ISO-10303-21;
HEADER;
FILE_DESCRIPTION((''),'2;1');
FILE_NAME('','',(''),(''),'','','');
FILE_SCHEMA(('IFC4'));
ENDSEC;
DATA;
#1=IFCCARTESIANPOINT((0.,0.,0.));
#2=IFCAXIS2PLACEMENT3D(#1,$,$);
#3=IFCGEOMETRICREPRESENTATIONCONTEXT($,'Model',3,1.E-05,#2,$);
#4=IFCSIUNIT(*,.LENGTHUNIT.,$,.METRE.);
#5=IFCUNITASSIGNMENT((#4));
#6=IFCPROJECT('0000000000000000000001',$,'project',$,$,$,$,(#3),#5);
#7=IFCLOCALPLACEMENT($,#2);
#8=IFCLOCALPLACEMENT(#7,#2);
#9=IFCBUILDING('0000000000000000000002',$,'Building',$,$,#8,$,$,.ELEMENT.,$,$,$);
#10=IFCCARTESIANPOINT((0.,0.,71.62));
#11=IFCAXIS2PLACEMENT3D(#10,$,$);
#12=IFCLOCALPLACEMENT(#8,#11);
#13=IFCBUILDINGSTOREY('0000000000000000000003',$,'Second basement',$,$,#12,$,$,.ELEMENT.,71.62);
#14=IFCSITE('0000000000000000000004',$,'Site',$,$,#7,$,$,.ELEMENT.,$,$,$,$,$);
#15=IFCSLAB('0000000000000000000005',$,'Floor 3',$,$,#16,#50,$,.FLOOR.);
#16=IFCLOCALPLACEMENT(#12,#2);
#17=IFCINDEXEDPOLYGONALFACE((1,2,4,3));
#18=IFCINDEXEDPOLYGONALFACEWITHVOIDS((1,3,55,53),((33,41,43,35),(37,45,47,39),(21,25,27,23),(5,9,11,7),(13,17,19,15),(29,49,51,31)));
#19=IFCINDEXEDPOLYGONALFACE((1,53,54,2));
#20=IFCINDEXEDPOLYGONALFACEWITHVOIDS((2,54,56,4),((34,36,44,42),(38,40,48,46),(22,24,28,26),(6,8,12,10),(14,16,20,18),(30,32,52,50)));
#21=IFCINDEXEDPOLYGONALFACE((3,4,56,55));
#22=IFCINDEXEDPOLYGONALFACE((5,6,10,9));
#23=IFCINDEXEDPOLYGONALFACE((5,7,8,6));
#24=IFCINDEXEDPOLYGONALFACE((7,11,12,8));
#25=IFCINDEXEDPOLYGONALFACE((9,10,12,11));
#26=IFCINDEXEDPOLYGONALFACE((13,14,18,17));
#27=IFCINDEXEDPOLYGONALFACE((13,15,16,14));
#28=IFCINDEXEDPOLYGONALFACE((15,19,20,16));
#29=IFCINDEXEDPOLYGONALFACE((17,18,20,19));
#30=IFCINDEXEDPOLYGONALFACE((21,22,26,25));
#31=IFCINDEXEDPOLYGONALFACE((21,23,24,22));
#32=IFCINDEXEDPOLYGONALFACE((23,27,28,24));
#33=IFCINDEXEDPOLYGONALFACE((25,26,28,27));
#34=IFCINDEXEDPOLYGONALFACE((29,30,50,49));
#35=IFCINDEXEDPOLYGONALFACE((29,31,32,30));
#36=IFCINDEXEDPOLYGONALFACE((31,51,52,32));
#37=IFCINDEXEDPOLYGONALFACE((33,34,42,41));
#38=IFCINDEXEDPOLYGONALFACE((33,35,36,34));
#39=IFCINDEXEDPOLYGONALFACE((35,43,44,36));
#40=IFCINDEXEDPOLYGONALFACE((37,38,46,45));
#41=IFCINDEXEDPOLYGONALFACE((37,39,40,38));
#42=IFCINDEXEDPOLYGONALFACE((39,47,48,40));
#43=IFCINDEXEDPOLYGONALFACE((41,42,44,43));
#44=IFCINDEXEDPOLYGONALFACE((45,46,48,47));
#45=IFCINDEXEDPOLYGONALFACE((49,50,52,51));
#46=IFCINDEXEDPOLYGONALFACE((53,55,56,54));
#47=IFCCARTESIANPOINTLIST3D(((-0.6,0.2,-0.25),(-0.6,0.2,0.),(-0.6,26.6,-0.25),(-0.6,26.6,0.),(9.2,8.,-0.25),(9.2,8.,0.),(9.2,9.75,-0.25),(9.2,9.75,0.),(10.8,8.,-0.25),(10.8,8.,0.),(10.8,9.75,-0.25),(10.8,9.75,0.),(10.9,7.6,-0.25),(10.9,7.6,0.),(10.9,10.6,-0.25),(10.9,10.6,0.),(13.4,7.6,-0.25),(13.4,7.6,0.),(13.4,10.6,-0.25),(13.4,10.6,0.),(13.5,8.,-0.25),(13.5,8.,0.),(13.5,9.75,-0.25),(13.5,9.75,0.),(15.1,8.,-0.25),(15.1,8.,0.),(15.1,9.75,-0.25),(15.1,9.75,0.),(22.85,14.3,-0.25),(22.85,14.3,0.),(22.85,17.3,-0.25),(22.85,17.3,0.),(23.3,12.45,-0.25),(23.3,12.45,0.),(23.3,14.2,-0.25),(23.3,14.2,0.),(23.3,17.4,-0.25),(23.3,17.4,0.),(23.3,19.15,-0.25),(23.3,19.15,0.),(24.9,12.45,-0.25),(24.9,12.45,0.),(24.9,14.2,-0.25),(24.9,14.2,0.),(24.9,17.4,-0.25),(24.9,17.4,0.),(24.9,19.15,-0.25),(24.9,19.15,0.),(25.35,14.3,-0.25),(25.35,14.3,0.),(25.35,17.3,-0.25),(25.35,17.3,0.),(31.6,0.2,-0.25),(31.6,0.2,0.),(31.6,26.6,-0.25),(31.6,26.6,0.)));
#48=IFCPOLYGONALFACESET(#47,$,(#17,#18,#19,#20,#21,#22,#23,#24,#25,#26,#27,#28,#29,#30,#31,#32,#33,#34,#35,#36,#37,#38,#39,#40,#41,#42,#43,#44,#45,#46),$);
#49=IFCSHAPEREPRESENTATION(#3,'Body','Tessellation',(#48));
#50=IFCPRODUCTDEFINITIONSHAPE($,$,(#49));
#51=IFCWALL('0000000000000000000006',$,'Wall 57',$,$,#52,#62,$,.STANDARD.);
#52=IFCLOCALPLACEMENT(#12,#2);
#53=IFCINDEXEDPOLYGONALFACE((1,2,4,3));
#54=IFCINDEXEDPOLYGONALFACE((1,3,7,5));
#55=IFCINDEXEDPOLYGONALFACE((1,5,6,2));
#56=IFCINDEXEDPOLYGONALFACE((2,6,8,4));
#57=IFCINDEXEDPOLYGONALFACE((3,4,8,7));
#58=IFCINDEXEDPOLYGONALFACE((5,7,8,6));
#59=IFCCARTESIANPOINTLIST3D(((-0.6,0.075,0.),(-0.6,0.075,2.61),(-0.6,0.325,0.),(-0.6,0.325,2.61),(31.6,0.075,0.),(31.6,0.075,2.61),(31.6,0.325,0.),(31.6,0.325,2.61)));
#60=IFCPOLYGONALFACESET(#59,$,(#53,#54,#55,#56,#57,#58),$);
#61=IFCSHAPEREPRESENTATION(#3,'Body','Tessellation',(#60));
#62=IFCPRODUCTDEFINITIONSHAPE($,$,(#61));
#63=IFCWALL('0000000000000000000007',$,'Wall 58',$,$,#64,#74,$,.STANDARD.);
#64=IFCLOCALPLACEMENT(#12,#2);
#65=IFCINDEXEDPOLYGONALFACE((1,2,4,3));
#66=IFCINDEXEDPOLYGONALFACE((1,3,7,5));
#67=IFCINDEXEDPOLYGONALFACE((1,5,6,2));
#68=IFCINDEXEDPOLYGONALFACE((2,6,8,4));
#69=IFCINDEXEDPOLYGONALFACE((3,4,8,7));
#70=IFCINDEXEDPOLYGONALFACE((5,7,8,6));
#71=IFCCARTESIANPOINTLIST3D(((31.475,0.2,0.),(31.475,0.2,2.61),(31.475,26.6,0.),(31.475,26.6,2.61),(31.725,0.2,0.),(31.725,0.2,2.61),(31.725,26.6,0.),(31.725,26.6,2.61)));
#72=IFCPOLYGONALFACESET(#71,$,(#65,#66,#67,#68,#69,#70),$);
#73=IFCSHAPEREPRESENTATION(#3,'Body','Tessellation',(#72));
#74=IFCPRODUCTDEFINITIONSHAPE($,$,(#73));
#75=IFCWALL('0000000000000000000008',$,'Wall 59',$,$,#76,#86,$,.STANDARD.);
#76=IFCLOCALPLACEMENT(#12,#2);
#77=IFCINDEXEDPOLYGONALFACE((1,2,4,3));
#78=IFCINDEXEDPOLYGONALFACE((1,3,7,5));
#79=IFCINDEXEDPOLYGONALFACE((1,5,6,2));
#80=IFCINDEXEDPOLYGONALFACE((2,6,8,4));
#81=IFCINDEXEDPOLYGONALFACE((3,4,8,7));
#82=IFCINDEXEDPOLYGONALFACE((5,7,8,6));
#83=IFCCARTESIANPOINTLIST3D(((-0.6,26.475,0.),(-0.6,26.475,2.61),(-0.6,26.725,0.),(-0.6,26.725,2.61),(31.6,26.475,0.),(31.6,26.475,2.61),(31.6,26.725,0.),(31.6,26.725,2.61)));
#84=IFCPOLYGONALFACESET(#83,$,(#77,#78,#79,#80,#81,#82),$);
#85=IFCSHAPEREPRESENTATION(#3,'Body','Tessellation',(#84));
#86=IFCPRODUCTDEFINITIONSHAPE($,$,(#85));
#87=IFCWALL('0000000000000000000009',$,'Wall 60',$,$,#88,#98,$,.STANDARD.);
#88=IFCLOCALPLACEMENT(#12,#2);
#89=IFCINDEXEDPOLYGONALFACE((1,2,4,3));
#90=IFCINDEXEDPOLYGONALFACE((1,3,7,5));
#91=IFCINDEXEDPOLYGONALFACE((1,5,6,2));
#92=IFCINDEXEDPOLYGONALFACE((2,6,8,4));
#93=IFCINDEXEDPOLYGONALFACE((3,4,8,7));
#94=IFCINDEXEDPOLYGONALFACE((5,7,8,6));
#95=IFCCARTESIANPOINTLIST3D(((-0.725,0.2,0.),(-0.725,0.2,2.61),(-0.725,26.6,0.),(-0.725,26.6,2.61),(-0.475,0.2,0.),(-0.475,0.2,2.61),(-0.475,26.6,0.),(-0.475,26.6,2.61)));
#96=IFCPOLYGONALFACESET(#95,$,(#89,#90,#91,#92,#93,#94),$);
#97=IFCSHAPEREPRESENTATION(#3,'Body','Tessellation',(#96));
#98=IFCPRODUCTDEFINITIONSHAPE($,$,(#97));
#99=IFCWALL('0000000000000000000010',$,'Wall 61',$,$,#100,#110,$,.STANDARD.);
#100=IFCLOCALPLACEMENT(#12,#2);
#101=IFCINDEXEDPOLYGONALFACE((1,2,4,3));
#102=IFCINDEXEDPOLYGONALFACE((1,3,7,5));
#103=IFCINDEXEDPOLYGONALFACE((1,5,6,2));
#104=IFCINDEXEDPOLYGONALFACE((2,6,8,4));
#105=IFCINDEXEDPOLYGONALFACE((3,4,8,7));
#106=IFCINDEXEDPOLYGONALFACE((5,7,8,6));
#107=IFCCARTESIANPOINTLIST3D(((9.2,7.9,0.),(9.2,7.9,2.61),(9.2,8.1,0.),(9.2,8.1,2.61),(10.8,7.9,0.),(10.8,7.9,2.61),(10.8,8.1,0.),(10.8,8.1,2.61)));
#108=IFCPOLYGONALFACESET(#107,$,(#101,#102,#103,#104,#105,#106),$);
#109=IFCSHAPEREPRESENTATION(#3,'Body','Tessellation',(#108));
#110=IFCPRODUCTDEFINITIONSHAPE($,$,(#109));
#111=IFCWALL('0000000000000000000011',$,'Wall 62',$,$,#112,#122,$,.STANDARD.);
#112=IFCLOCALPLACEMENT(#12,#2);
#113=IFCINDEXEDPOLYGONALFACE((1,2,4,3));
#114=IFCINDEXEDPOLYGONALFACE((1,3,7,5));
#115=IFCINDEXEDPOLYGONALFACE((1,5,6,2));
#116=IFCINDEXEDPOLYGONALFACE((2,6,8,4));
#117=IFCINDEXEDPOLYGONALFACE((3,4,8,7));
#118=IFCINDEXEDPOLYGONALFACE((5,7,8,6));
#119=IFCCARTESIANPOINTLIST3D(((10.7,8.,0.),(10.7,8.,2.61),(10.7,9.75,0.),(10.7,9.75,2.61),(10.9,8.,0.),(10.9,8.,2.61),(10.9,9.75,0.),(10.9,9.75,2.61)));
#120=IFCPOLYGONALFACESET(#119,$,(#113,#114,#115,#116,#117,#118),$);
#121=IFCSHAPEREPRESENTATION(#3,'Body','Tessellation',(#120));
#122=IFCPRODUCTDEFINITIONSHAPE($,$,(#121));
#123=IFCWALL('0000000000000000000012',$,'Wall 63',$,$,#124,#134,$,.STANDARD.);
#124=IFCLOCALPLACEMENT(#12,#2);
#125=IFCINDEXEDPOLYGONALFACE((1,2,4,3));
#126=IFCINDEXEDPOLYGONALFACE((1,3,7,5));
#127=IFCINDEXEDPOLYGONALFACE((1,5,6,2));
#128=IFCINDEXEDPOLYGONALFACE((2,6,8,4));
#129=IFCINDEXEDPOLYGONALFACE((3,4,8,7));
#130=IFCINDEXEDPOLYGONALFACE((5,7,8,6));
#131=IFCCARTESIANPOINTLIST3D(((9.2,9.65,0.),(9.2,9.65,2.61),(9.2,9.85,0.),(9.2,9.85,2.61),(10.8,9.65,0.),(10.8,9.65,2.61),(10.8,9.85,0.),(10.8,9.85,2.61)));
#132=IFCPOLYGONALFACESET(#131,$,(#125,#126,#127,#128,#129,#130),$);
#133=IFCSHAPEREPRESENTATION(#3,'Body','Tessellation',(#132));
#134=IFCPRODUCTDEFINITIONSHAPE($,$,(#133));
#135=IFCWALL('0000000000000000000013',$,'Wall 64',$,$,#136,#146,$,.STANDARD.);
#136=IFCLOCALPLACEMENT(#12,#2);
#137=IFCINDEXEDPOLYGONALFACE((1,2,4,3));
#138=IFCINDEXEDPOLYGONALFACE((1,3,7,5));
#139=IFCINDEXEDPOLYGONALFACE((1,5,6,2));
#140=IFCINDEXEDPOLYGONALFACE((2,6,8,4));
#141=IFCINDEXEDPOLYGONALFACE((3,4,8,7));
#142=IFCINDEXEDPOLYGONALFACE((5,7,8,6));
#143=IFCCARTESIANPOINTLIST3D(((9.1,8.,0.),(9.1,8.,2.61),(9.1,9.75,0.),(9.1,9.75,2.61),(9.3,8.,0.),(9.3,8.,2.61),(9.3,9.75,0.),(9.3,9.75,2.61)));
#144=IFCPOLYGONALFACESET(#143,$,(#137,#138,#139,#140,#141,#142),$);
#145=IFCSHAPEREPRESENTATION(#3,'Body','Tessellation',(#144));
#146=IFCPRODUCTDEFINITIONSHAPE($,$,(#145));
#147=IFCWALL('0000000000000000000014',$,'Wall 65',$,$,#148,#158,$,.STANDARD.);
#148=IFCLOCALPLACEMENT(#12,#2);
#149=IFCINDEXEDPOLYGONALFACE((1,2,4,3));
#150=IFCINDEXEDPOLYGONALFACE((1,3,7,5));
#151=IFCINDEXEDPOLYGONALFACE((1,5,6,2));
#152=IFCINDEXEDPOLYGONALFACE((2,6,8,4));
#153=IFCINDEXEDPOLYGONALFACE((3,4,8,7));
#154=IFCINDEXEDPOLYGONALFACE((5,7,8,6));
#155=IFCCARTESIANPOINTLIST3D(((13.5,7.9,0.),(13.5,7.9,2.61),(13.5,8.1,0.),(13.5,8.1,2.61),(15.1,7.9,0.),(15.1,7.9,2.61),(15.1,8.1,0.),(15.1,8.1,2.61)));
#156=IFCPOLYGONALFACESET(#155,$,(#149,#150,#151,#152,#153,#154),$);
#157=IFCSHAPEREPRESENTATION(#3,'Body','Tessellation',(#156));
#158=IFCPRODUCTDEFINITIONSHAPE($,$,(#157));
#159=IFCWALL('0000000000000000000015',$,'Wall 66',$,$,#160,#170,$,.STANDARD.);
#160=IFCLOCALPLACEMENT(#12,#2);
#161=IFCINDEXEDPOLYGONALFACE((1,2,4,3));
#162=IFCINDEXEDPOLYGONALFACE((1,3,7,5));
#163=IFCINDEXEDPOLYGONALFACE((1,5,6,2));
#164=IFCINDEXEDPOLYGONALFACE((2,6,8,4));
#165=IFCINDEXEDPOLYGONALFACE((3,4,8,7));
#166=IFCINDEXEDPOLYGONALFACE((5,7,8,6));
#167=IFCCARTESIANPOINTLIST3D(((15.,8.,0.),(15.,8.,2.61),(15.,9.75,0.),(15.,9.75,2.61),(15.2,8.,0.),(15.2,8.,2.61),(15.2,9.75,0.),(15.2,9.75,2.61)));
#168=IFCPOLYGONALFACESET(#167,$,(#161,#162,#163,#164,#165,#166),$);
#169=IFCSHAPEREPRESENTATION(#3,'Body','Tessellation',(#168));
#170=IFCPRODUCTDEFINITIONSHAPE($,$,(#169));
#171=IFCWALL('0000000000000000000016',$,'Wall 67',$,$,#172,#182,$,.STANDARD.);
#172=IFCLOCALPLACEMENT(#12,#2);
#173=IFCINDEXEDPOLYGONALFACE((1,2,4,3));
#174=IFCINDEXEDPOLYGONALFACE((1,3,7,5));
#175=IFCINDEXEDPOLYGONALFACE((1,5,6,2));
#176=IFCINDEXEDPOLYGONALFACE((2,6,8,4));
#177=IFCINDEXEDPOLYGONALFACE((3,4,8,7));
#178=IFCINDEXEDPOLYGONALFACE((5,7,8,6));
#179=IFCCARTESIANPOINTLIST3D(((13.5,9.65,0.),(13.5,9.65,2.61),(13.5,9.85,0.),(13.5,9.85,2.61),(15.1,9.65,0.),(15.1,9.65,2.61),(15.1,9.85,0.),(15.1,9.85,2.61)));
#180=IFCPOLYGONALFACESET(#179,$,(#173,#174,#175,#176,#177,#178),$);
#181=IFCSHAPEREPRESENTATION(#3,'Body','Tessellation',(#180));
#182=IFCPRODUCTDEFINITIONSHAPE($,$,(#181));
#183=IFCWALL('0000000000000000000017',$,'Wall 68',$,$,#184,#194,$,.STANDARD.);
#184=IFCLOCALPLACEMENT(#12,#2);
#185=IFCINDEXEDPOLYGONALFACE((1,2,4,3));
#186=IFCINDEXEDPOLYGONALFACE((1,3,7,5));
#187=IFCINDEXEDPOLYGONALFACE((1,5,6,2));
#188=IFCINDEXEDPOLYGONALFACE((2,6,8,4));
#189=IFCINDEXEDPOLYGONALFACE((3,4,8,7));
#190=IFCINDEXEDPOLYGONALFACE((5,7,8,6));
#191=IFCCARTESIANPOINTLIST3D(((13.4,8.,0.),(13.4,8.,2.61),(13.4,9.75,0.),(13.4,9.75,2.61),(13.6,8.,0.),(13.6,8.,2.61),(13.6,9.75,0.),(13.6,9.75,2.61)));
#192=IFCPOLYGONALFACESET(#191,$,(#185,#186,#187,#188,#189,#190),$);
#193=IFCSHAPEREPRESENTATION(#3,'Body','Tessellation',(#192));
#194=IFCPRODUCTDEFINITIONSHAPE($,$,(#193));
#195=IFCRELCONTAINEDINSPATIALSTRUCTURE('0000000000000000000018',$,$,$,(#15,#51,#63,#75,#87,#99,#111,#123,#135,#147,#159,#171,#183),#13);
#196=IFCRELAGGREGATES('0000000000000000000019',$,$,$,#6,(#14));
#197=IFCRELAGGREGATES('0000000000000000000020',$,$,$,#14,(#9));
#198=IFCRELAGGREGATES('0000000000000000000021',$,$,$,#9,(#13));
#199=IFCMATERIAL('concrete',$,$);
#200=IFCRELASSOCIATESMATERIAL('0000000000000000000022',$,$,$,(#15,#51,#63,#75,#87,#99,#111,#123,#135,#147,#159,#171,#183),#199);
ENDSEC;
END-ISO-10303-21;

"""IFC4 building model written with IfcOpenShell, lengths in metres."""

from ifc_helpers import new_model, si_unit, frame, frame_2d, origin, place, context, project, spatial, polyline, rectangle, outline, extrude, material, element, save


model = new_model("IFC4")

# Units and contexts
model_context = context("Model", 3, precision=1e-05, world=origin())
ifc_project = project(units=[si_unit("LENGTHUNIT", "METRE")], contexts=[model_context])

# Site, building, storey
site_placement = place(None, origin())
site = spatial("IfcSite", under=ifc_project, at=site_placement, Name="Site", CompositionType="ELEMENT")
building_placement = place(site_placement, origin())
building = spatial("IfcBuilding", under=site, at=building_placement, Name="Building", CompositionType="ELEMENT")
storey_placement = place(building_placement, frame((0.0, 0.0, 71.62)))
storey = spatial("IfcBuildingStorey", under=building, at=storey_placement, Name="Second basement", CompositionType="ELEMENT", Elevation=71.62)

# Slab
ifc_material = material(Name="concrete")
slab_placement = place(storey_placement, frame((0.0, 0.0, -0.25), z_axis=(0.0, 0.0, 1.0), x_axis=(1.0, 0.0, 0.0)))
element("IfcSlab", 1, at=slab_placement, inside=storey, material=ifc_material, Name="Floor 3", PredefinedType="FLOOR", context=model_context, shape_type="SweptSolid", body=[
    extrude(outline(polyline([(-0.6, 0.2), (31.6, 0.2), (31.6, 26.6), (-0.6, 26.6), (-0.6, 0.2)]), holes=[polyline([(10.9, 7.6), (13.4, 7.6), (13.4, 10.6), (10.9, 10.6), (10.9, 7.6)]), polyline([(9.2, 8.0), (10.8, 8.0), (10.8, 9.75), (9.2, 9.75), (9.2, 8.0)]), polyline([(13.5, 8.0), (15.1, 8.0), (15.1, 9.75), (13.5, 9.75), (13.5, 8.0)]), polyline([(22.85, 14.3), (25.35, 14.3), (25.35, 17.3), (22.85, 17.3), (22.85, 14.3)]), polyline([(23.3, 17.4), (24.9, 17.4), (24.9, 19.15), (23.3, 19.15), (23.3, 17.4)]), polyline([(23.3, 12.45), (24.9, 12.45), (24.9, 14.2), (23.3, 14.2), (23.3, 12.45)])]), origin(), (0.0, 0.0, 1.0), 0.25),
])

# Walls
wall_1_placement = place(storey_placement, frame((-0.6, 0.2, 0.0), z_axis=(0.0, 0.0, 1.0), x_axis=(1.0, 0.0, 0.0)))
element("IfcWall", 2, at=wall_1_placement, inside=storey, material=ifc_material, Name="Wall 57", PredefinedType="STANDARD", context=model_context, shape_type="SweptSolid", body=[
    extrude(rectangle(XDim=32.2, YDim=0.25, at=frame_2d((16.1, 0.0))), origin(), (0.0, 0.0, 1.0), 2.61),
])
wall_2_placement = place(storey_placement, frame((31.6, 0.2, 0.0), z_axis=(0.0, 0.0, 1.0), x_axis=(0.0, 1.0, 0.0)))
element("IfcWall", 3, at=wall_2_placement, inside=storey, material=ifc_material, Name="Wall 58", PredefinedType="STANDARD", context=model_context, shape_type="SweptSolid", body=[
    extrude(rectangle(XDim=26.4, YDim=0.25, at=frame_2d((13.2, 0.0))), origin(), (0.0, 0.0, 1.0), 2.61),
])
wall_3_placement = place(storey_placement, frame((31.6, 26.6, 0.0), z_axis=(0.0, 0.0, 1.0), x_axis=(-1.0, 0.0, 0.0)))
element("IfcWall", 4, at=wall_3_placement, inside=storey, material=ifc_material, Name="Wall 59", PredefinedType="STANDARD", context=model_context, shape_type="SweptSolid", body=[
    extrude(rectangle(XDim=32.2, YDim=0.25, at=frame_2d((16.1, 0.0))), origin(), (0.0, 0.0, 1.0), 2.61),
])
wall_4_placement = place(storey_placement, frame((-0.6, 26.6, 0.0), z_axis=(0.0, 0.0, 1.0), x_axis=(0.0, -1.0, 0.0)))
element("IfcWall", 5, at=wall_4_placement, inside=storey, material=ifc_material, Name="Wall 60", PredefinedType="STANDARD", context=model_context, shape_type="SweptSolid", body=[
    extrude(rectangle(XDim=26.4, YDim=0.25, at=frame_2d((13.2, 0.0))), origin(), (0.0, 0.0, 1.0), 2.61),
])
wall_5_placement = place(storey_placement, frame((9.2, 8.0, 0.0), z_axis=(0.0, 0.0, 1.0), x_axis=(1.0, 0.0, 0.0)))
element("IfcWall", 6, at=wall_5_placement, inside=storey, material=ifc_material, Name="Wall 61", PredefinedType="STANDARD", context=model_context, shape_type="SweptSolid", body=[
    extrude(rectangle(XDim=1.6, YDim=0.2, at=frame_2d((0.8, 0.0))), origin(), (0.0, 0.0, 1.0), 2.61),
])
wall_6_placement = place(storey_placement, frame((10.8, 8.0, 0.0), z_axis=(0.0, 0.0, 1.0), x_axis=(0.0, 1.0, 0.0)))
element("IfcWall", 7, at=wall_6_placement, inside=storey, material=ifc_material, Name="Wall 62", PredefinedType="STANDARD", context=model_context, shape_type="SweptSolid", body=[
    extrude(rectangle(XDim=1.75, YDim=0.2, at=frame_2d((0.875, 0.0))), origin(), (0.0, 0.0, 1.0), 2.61),
])
wall_7_placement = place(storey_placement, frame((10.8, 9.75, 0.0), z_axis=(0.0, 0.0, 1.0), x_axis=(-1.0, 0.0, 0.0)))
element("IfcWall", 8, at=wall_7_placement, inside=storey, material=ifc_material, Name="Wall 63", PredefinedType="STANDARD", context=model_context, shape_type="SweptSolid", body=[
    extrude(rectangle(XDim=1.6, YDim=0.2, at=frame_2d((0.8, 0.0))), origin(), (0.0, 0.0, 1.0), 2.61),
])
wall_8_placement = place(storey_placement, frame((9.2, 9.75, 0.0), z_axis=(0.0, 0.0, 1.0), x_axis=(0.0, -1.0, 0.0)))
element("IfcWall", 9, at=wall_8_placement, inside=storey, material=ifc_material, Name="Wall 64", PredefinedType="STANDARD", context=model_context, shape_type="SweptSolid", body=[
    extrude(rectangle(XDim=1.75, YDim=0.2, at=frame_2d((0.875, 0.0))), origin(), (0.0, 0.0, 1.0), 2.61),
])
wall_9_placement = place(storey_placement, frame((13.5, 8.0, 0.0), z_axis=(0.0, 0.0, 1.0), x_axis=(1.0, 0.0, 0.0)))
element("IfcWall", 10, at=wall_9_placement, inside=storey, material=ifc_material, Name="Wall 65", PredefinedType="STANDARD", context=model_context, shape_type="SweptSolid", body=[
    extrude(rectangle(XDim=1.6, YDim=0.2, at=frame_2d((0.8, 0.0))), origin(), (0.0, 0.0, 1.0), 2.61),
])
wall_10_placement = place(storey_placement, frame((15.1, 8.0, 0.0), z_axis=(0.0, 0.0, 1.0), x_axis=(0.0, 1.0, 0.0)))
element("IfcWall", 11, at=wall_10_placement, inside=storey, material=ifc_material, Name="Wall 66", PredefinedType="STANDARD", context=model_context, shape_type="SweptSolid", body=[
    extrude(rectangle(XDim=1.75, YDim=0.2, at=frame_2d((0.875, 0.0))), origin(), (0.0, 0.0, 1.0), 2.61),
])
wall_11_placement = place(storey_placement, frame((15.1, 9.75, 0.0), z_axis=(0.0, 0.0, 1.0), x_axis=(-1.0, 0.0, 0.0)))
element("IfcWall", 12, at=wall_11_placement, inside=storey, material=ifc_material, Name="Wall 67", PredefinedType="STANDARD", context=model_context, shape_type="SweptSolid", body=[
    extrude(rectangle(XDim=1.6, YDim=0.2, at=frame_2d((0.8, 0.0))), origin(), (0.0, 0.0, 1.0), 2.61),
])
wall_12_placement = place(storey_placement, frame((13.5, 9.75, 0.0), z_axis=(0.0, 0.0, 1.0), x_axis=(0.0, -1.0, 0.0)))
element("IfcWall", 13, at=wall_12_placement, inside=storey, material=ifc_material, Name="Wall 68", PredefinedType="STANDARD", context=model_context, shape_type="SweptSolid", body=[
    extrude(rectangle(XDim=1.75, YDim=0.2, at=frame_2d((0.875, 0.0))), origin(), (0.0, 0.0, 1.0), 2.61),
])

save(model, "model.ifc")
